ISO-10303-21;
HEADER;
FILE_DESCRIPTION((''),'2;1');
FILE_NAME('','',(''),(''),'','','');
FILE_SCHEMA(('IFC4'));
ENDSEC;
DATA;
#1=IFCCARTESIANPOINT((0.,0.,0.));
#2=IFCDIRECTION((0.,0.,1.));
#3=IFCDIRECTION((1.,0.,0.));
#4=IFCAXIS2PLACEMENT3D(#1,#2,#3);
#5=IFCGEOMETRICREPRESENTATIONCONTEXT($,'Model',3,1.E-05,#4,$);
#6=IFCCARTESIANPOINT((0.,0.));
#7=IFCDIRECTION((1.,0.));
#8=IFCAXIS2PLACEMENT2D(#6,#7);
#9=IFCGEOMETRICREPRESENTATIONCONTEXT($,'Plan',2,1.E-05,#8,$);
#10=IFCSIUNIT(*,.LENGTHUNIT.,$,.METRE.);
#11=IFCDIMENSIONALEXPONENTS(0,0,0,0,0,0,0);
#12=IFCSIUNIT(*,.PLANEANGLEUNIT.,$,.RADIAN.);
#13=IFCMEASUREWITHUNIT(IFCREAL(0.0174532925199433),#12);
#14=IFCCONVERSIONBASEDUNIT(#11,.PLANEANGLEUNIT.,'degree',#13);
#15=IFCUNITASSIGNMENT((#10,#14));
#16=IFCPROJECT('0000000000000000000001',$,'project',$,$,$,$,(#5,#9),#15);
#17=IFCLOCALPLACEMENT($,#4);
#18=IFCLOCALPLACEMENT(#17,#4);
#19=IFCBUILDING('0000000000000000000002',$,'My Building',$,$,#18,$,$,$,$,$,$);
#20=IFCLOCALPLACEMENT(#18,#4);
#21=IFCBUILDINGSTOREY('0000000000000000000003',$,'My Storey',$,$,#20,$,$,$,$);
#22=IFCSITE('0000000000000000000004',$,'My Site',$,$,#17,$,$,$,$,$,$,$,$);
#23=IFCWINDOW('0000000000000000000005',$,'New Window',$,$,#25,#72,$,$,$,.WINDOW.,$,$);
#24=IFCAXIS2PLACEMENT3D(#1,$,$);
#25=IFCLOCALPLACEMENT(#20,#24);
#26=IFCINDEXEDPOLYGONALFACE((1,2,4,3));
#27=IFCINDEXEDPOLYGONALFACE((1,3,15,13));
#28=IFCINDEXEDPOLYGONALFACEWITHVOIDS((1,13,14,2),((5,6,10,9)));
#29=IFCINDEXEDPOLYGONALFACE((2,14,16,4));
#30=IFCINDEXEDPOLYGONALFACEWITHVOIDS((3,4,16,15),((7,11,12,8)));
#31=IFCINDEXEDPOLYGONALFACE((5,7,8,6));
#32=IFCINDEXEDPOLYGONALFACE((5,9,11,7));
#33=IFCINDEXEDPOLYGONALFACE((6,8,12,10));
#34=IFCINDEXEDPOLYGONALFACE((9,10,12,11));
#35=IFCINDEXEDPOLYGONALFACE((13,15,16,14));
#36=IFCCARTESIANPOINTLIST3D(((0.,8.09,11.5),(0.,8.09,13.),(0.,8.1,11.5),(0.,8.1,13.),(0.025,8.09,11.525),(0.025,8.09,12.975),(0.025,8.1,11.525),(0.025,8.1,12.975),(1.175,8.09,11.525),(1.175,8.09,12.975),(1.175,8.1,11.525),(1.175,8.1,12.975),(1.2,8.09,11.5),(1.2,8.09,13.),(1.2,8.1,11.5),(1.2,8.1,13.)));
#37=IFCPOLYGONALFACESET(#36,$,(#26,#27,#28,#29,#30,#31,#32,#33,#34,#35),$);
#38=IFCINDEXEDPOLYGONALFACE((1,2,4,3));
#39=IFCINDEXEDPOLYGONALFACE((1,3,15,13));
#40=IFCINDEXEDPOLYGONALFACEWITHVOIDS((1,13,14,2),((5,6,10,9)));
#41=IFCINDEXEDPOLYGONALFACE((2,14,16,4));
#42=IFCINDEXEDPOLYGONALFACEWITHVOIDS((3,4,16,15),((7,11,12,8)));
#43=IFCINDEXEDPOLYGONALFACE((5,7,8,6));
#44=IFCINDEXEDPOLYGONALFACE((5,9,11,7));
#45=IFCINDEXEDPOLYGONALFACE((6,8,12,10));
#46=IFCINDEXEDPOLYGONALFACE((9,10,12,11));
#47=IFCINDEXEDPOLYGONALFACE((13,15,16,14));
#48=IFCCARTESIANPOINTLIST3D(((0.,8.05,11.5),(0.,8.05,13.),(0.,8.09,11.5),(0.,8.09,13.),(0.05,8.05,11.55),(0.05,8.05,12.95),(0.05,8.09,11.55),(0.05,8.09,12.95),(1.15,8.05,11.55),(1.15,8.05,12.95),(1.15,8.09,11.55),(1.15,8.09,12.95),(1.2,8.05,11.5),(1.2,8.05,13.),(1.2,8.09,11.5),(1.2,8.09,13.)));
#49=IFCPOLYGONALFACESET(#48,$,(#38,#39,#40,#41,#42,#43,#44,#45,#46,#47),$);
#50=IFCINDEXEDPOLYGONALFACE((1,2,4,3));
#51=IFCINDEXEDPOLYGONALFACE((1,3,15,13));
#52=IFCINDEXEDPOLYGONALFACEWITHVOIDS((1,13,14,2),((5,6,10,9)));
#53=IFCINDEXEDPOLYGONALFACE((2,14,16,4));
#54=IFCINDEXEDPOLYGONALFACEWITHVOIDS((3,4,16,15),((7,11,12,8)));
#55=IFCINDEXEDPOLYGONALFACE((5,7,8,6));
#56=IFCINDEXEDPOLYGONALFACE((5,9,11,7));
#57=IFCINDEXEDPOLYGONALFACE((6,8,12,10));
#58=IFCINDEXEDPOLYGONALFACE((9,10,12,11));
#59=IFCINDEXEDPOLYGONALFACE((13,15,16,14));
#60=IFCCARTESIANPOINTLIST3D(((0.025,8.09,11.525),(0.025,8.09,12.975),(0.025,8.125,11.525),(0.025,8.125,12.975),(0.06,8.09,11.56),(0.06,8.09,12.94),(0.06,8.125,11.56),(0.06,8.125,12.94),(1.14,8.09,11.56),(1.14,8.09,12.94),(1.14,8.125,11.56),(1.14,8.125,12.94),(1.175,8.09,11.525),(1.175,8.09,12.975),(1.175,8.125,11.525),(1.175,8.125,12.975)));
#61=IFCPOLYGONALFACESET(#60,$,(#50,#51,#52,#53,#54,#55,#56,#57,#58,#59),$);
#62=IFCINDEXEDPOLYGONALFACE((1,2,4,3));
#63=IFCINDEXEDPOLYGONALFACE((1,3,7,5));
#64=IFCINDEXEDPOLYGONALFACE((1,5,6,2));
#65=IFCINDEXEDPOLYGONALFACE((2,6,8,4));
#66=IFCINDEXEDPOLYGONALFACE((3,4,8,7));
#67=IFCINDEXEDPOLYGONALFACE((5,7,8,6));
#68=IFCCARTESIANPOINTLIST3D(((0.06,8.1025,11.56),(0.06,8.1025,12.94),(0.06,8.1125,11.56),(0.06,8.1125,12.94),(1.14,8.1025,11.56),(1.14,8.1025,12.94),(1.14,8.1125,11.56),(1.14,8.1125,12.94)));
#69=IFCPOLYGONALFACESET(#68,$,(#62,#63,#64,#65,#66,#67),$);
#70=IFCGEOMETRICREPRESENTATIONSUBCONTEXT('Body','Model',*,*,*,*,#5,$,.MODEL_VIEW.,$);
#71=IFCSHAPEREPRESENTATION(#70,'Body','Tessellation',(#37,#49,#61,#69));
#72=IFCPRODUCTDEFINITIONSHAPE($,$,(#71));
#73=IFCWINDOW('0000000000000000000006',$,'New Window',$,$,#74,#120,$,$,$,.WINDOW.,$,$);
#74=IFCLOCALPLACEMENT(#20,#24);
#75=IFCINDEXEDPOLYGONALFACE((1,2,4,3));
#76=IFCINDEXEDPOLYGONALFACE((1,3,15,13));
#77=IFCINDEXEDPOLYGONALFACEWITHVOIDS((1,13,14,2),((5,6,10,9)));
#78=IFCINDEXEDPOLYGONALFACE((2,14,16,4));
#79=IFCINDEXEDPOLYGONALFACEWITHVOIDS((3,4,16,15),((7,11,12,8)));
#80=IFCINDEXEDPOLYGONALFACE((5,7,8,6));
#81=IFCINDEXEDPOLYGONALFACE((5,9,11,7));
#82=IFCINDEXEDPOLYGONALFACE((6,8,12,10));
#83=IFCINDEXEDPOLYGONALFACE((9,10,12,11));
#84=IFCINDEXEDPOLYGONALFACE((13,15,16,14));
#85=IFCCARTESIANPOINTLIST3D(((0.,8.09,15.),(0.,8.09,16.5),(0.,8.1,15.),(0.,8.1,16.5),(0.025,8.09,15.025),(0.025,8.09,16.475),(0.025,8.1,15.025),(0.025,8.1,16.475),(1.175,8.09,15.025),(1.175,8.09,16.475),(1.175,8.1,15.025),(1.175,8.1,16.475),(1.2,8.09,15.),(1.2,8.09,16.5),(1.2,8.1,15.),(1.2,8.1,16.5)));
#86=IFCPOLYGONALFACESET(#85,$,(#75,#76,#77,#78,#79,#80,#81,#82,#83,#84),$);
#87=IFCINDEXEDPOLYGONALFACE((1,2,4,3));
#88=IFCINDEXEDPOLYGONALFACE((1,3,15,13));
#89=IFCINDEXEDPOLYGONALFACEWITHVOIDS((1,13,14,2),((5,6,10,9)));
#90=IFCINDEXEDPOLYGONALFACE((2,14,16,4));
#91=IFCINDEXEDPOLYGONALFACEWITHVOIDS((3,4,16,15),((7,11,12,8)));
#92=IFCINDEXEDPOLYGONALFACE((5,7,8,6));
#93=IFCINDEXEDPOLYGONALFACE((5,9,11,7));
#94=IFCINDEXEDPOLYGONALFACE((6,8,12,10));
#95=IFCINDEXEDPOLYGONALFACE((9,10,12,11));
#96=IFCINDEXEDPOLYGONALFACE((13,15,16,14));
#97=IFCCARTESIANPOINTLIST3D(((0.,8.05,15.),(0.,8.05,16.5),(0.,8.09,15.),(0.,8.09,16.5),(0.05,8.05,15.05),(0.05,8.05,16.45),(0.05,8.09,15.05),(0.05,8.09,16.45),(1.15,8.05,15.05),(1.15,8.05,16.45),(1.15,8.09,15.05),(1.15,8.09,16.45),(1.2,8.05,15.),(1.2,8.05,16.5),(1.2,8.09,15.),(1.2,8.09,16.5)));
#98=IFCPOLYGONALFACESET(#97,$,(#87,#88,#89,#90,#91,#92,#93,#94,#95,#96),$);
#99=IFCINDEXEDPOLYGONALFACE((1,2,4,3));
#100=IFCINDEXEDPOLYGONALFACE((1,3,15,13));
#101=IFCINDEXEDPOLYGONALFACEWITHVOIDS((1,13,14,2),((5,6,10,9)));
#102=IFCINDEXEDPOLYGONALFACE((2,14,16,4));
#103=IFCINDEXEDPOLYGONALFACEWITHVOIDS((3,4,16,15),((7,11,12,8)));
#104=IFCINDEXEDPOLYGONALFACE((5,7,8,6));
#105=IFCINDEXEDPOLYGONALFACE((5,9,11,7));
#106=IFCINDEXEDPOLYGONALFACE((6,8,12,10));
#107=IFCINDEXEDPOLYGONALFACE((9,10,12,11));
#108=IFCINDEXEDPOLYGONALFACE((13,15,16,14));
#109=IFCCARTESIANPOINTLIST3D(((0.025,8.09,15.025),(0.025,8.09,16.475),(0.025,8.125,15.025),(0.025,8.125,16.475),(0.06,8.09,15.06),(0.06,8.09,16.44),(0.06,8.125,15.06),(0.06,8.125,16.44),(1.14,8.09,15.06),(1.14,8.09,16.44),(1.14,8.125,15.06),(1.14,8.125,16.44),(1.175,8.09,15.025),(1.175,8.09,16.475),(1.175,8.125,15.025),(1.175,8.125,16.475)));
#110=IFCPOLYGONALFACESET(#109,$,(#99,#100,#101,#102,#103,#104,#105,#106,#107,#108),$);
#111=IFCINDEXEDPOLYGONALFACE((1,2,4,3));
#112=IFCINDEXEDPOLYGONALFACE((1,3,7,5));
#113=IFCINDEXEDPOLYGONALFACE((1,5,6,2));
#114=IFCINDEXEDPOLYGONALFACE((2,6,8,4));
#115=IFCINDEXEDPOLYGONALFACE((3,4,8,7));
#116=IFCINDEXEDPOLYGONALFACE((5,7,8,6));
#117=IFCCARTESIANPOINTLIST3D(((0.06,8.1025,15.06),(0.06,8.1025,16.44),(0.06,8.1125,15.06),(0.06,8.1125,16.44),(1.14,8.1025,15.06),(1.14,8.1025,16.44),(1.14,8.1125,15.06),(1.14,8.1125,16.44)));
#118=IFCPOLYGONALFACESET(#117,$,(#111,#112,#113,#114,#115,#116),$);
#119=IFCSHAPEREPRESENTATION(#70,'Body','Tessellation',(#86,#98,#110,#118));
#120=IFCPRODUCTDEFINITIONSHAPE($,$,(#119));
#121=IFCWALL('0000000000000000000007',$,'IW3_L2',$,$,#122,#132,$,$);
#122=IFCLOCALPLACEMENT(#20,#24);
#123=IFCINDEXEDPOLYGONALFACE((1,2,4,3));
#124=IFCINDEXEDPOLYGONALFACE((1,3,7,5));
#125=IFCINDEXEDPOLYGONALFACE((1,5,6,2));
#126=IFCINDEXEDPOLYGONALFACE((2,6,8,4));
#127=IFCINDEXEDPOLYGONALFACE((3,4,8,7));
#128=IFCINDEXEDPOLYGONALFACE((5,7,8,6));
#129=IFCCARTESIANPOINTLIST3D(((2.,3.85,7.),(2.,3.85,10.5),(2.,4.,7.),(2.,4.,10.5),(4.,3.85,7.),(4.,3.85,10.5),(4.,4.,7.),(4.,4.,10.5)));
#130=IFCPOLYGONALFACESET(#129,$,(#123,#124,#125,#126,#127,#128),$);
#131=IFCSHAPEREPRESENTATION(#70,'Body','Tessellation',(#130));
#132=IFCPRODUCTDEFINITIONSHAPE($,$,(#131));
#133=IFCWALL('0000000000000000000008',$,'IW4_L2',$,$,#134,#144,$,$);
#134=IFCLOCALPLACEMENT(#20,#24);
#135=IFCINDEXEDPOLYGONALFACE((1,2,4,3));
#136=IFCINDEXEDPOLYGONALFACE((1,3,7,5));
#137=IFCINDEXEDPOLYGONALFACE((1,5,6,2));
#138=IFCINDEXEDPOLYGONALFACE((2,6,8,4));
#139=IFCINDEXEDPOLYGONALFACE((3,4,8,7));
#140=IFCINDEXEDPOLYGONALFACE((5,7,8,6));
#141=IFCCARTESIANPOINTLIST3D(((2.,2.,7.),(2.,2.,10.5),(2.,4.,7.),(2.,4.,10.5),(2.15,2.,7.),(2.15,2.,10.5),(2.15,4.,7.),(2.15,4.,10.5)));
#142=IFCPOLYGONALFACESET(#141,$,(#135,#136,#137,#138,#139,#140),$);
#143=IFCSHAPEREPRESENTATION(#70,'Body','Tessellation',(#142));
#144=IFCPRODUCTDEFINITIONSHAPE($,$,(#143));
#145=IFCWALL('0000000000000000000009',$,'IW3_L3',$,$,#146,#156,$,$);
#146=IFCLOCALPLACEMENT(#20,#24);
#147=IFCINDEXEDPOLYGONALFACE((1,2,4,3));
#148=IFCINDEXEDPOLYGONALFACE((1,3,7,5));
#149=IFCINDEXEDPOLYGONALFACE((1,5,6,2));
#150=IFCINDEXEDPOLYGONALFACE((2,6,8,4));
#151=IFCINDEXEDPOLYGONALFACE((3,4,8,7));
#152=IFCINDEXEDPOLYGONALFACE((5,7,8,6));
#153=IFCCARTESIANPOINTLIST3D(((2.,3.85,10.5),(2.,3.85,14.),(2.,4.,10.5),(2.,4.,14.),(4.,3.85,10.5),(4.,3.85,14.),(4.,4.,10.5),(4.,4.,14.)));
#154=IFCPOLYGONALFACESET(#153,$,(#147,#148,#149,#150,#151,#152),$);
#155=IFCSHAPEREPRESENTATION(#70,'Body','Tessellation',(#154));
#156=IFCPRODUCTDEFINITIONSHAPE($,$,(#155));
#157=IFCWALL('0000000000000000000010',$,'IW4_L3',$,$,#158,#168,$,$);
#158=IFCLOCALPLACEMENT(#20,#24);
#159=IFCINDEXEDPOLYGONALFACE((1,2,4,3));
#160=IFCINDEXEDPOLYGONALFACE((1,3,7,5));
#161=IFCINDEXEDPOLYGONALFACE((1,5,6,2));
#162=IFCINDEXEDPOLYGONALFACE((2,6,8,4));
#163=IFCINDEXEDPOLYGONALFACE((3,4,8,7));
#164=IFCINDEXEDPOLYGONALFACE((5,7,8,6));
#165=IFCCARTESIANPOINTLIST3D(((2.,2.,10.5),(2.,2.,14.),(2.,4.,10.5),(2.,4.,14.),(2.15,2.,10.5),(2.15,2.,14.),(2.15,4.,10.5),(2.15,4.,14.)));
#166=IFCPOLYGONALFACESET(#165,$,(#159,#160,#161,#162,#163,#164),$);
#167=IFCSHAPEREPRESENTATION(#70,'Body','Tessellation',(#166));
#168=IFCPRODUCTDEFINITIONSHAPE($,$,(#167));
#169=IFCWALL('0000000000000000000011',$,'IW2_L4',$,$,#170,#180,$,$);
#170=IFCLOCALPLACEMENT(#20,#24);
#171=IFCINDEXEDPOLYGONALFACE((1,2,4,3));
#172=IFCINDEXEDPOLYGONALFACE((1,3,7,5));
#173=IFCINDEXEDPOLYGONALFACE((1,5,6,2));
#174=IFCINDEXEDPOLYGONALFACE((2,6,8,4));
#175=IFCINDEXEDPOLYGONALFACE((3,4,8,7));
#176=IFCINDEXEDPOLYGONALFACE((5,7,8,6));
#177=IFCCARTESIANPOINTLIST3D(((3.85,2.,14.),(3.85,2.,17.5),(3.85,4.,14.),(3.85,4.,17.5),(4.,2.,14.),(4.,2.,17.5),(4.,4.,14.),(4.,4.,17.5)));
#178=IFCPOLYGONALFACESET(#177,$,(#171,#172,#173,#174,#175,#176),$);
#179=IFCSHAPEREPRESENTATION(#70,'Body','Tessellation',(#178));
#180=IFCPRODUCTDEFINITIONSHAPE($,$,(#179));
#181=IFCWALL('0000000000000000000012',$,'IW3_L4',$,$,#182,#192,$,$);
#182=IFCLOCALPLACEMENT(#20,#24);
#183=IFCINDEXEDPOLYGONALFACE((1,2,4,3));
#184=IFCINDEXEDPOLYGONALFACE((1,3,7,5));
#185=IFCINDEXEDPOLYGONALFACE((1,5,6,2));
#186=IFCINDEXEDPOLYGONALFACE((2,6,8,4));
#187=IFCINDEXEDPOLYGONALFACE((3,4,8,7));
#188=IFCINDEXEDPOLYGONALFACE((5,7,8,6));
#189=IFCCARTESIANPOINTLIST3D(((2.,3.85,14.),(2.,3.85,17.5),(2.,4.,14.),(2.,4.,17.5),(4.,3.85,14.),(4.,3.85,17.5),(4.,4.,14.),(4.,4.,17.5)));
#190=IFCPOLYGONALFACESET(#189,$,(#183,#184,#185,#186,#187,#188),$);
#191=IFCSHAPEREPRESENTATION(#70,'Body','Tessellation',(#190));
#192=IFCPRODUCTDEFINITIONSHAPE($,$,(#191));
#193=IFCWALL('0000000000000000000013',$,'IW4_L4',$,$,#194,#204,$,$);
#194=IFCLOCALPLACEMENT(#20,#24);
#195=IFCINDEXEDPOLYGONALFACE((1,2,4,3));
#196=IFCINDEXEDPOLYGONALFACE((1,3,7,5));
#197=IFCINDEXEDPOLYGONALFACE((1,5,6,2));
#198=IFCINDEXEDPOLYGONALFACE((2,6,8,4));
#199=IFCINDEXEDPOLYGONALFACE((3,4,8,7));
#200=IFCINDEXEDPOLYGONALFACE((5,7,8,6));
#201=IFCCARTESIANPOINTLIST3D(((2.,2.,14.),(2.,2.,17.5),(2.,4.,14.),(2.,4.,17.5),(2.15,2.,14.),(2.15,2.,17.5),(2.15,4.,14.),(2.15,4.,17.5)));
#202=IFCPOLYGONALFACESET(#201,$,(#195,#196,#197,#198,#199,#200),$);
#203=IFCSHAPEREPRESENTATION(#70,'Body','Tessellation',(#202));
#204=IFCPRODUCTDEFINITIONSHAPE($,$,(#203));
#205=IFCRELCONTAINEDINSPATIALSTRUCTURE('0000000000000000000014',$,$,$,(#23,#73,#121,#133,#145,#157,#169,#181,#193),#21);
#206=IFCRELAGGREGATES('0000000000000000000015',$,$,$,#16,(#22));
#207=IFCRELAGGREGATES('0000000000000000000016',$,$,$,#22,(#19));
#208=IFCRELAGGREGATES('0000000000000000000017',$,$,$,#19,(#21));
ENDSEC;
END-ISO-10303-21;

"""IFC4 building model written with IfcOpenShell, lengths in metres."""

from ifc_helpers import new_model, entity, si_unit, converted_unit, frame, origin_with_axes, origin_2d_with_axis, place, context, subcontext, project, spatial, line, indexed_curve, outline, extrude, element, save


model = new_model("IFC4")

# Units and contexts
model_context = context("Model", 3, precision=1e-05, world=origin_with_axes())
plan_context = context("Plan", 2, precision=1e-05, world=origin_2d_with_axis())
body_context = subcontext(model_context, "Body", "Model", "MODEL_VIEW")
ifc_project = project(units=[si_unit("LENGTHUNIT", "METRE"), converted_unit("PLANEANGLEUNIT", "degree", entity("IfcReal", 0.0174532925199433), si_unit("PLANEANGLEUNIT", "RADIAN"), dimensions=[0, 0, 0, 0, 0, 0, 0])], contexts=[model_context, plan_context])

# Site, building, storey
site_placement = place(None, origin_with_axes())
site = spatial("IfcSite", under=ifc_project, at=site_placement, Name="My Site")
building_placement = place(site_placement, origin_with_axes())
building = spatial("IfcBuilding", under=site, at=building_placement, Name="My Building")
storey_placement = place(building_placement, origin_with_axes())
storey = spatial("IfcBuildingStorey", under=building, at=storey_placement, Name="My Storey")

# Windows
for number, where, z_axis, x_axis, name in (
    (1, (0.0, 8.0, 11.5), (0.0, 0.0, 1.0), (1.0, 0.0, 0.0), "New Window"),
    (2, (0.0, 8.0, 15.0), (0.0, 0.0, 1.0), (1.0, 0.0, 0.0), "New Window"),
):
    element("IfcWindow", number, at=place(storey_placement, frame(where, z_axis=z_axis, x_axis=x_axis)), inside=storey, Name=name, PredefinedType="WINDOW", context=body_context, shape_type="SweptSolid", body=[
        extrude(outline(indexed_curve([(0.0, 0.0), (1.2, 0.0), (1.2, 1.5), (0.0, 1.5)], segments=[line(1, 2, 3, 4, 1)]), holes=[indexed_curve([(0.025, 0.025), (1.175, 0.025), (1.175, 1.475), (0.025, 1.475)], segments=[line(1, 2, 3, 4, 1)])]), frame((0.0, 0.09, 0.0), z_axis=(0.0, -1.0, 0.0), x_axis=(1.0, 0.0, 0.0)), (0.0, 0.0, -1.0), 0.01),
        extrude(outline(indexed_curve([(0.0, 0.0), (1.2, 0.0), (1.2, 1.5), (0.0, 1.5)], segments=[line(1, 2, 3, 4, 1)]), holes=[indexed_curve([(0.05, 0.05), (1.15, 0.05), (1.15, 1.45), (0.05, 1.45)], segments=[line(1, 2, 3, 4, 1)])]), frame((0.0, 0.05, 0.0), z_axis=(0.0, -1.0, 0.0), x_axis=(1.0, 0.0, 0.0)), (0.0, 0.0, -1.0), 0.04),
        extrude(outline(indexed_curve([(0.0, 0.0), (1.15, 0.0), (1.15, 1.45), (0.0, 1.45)], segments=[line(1, 2, 3, 4, 1)]), holes=[indexed_curve([(0.035, 0.035), (1.115, 0.035), (1.115, 1.415), (0.035, 1.415)], segments=[line(1, 2, 3, 4, 1)])]), frame((0.025, 0.09, 0.025), z_axis=(0.0, -1.0, 0.0), x_axis=(1.0, 0.0, 0.0)), (0.0, 0.0, -1.0), 0.035),
        extrude(outline(indexed_curve([(0.035, 0.035), (1.115, 0.035), (1.115, 1.415), (0.035, 1.415)], segments=[line(1, 2, 3, 4, 1)])), frame((0.025, 0.1025, 0.025), z_axis=(0.0, -1.0, 0.0), x_axis=(1.0, 0.0, 0.0)), (0.0, 0.0, -1.0), 0.01),
    ])

# Walls
for number, where, z_axis, x_axis, name in (
    (3, (4.0, 4.0, 7.0), (0.0, 0.0, 1.0), (-1.0, 0.0, 0.0), "IW3_L2"),
    (4, (2.0, 4.0, 7.0), (0.0, 0.0, 1.0), (0.0, -1.0, 0.0), "IW4_L2"),
    (5, (4.0, 4.0, 10.5), (0.0, 0.0, 1.0), (-1.0, 0.0, 0.0), "IW3_L3"),
    (6, (2.0, 4.0, 10.5), (0.0, 0.0, 1.0), (0.0, -1.0, 0.0), "IW4_L3"),
    (7, (4.0, 2.0, 14.0), (0.0, 0.0, 1.0), (0.0, 1.0, 0.0), "IW2_L4"),
    (8, (4.0, 4.0, 14.0), (0.0, 0.0, 1.0), (-1.0, 0.0, 0.0), "IW3_L4"),
    (9, (2.0, 4.0, 14.0), (0.0, 0.0, 1.0), (0.0, -1.0, 0.0), "IW4_L4"),
):
    element("IfcWall", number, at=place(storey_placement, frame(where, z_axis=z_axis, x_axis=x_axis)), inside=storey, Name=name, context=body_context, shape_type="SweptSolid", body=[
        extrude(outline(indexed_curve([(0.0, 0.0), (0.0, 0.15), (2.0, 0.15), (2.0, 0.0), (0.0, 0.0)], self_intersect=False)), origin_with_axes(), (0.0, 0.0, 1.0), 3.5),
    ])

save(model, "model.ifc")
